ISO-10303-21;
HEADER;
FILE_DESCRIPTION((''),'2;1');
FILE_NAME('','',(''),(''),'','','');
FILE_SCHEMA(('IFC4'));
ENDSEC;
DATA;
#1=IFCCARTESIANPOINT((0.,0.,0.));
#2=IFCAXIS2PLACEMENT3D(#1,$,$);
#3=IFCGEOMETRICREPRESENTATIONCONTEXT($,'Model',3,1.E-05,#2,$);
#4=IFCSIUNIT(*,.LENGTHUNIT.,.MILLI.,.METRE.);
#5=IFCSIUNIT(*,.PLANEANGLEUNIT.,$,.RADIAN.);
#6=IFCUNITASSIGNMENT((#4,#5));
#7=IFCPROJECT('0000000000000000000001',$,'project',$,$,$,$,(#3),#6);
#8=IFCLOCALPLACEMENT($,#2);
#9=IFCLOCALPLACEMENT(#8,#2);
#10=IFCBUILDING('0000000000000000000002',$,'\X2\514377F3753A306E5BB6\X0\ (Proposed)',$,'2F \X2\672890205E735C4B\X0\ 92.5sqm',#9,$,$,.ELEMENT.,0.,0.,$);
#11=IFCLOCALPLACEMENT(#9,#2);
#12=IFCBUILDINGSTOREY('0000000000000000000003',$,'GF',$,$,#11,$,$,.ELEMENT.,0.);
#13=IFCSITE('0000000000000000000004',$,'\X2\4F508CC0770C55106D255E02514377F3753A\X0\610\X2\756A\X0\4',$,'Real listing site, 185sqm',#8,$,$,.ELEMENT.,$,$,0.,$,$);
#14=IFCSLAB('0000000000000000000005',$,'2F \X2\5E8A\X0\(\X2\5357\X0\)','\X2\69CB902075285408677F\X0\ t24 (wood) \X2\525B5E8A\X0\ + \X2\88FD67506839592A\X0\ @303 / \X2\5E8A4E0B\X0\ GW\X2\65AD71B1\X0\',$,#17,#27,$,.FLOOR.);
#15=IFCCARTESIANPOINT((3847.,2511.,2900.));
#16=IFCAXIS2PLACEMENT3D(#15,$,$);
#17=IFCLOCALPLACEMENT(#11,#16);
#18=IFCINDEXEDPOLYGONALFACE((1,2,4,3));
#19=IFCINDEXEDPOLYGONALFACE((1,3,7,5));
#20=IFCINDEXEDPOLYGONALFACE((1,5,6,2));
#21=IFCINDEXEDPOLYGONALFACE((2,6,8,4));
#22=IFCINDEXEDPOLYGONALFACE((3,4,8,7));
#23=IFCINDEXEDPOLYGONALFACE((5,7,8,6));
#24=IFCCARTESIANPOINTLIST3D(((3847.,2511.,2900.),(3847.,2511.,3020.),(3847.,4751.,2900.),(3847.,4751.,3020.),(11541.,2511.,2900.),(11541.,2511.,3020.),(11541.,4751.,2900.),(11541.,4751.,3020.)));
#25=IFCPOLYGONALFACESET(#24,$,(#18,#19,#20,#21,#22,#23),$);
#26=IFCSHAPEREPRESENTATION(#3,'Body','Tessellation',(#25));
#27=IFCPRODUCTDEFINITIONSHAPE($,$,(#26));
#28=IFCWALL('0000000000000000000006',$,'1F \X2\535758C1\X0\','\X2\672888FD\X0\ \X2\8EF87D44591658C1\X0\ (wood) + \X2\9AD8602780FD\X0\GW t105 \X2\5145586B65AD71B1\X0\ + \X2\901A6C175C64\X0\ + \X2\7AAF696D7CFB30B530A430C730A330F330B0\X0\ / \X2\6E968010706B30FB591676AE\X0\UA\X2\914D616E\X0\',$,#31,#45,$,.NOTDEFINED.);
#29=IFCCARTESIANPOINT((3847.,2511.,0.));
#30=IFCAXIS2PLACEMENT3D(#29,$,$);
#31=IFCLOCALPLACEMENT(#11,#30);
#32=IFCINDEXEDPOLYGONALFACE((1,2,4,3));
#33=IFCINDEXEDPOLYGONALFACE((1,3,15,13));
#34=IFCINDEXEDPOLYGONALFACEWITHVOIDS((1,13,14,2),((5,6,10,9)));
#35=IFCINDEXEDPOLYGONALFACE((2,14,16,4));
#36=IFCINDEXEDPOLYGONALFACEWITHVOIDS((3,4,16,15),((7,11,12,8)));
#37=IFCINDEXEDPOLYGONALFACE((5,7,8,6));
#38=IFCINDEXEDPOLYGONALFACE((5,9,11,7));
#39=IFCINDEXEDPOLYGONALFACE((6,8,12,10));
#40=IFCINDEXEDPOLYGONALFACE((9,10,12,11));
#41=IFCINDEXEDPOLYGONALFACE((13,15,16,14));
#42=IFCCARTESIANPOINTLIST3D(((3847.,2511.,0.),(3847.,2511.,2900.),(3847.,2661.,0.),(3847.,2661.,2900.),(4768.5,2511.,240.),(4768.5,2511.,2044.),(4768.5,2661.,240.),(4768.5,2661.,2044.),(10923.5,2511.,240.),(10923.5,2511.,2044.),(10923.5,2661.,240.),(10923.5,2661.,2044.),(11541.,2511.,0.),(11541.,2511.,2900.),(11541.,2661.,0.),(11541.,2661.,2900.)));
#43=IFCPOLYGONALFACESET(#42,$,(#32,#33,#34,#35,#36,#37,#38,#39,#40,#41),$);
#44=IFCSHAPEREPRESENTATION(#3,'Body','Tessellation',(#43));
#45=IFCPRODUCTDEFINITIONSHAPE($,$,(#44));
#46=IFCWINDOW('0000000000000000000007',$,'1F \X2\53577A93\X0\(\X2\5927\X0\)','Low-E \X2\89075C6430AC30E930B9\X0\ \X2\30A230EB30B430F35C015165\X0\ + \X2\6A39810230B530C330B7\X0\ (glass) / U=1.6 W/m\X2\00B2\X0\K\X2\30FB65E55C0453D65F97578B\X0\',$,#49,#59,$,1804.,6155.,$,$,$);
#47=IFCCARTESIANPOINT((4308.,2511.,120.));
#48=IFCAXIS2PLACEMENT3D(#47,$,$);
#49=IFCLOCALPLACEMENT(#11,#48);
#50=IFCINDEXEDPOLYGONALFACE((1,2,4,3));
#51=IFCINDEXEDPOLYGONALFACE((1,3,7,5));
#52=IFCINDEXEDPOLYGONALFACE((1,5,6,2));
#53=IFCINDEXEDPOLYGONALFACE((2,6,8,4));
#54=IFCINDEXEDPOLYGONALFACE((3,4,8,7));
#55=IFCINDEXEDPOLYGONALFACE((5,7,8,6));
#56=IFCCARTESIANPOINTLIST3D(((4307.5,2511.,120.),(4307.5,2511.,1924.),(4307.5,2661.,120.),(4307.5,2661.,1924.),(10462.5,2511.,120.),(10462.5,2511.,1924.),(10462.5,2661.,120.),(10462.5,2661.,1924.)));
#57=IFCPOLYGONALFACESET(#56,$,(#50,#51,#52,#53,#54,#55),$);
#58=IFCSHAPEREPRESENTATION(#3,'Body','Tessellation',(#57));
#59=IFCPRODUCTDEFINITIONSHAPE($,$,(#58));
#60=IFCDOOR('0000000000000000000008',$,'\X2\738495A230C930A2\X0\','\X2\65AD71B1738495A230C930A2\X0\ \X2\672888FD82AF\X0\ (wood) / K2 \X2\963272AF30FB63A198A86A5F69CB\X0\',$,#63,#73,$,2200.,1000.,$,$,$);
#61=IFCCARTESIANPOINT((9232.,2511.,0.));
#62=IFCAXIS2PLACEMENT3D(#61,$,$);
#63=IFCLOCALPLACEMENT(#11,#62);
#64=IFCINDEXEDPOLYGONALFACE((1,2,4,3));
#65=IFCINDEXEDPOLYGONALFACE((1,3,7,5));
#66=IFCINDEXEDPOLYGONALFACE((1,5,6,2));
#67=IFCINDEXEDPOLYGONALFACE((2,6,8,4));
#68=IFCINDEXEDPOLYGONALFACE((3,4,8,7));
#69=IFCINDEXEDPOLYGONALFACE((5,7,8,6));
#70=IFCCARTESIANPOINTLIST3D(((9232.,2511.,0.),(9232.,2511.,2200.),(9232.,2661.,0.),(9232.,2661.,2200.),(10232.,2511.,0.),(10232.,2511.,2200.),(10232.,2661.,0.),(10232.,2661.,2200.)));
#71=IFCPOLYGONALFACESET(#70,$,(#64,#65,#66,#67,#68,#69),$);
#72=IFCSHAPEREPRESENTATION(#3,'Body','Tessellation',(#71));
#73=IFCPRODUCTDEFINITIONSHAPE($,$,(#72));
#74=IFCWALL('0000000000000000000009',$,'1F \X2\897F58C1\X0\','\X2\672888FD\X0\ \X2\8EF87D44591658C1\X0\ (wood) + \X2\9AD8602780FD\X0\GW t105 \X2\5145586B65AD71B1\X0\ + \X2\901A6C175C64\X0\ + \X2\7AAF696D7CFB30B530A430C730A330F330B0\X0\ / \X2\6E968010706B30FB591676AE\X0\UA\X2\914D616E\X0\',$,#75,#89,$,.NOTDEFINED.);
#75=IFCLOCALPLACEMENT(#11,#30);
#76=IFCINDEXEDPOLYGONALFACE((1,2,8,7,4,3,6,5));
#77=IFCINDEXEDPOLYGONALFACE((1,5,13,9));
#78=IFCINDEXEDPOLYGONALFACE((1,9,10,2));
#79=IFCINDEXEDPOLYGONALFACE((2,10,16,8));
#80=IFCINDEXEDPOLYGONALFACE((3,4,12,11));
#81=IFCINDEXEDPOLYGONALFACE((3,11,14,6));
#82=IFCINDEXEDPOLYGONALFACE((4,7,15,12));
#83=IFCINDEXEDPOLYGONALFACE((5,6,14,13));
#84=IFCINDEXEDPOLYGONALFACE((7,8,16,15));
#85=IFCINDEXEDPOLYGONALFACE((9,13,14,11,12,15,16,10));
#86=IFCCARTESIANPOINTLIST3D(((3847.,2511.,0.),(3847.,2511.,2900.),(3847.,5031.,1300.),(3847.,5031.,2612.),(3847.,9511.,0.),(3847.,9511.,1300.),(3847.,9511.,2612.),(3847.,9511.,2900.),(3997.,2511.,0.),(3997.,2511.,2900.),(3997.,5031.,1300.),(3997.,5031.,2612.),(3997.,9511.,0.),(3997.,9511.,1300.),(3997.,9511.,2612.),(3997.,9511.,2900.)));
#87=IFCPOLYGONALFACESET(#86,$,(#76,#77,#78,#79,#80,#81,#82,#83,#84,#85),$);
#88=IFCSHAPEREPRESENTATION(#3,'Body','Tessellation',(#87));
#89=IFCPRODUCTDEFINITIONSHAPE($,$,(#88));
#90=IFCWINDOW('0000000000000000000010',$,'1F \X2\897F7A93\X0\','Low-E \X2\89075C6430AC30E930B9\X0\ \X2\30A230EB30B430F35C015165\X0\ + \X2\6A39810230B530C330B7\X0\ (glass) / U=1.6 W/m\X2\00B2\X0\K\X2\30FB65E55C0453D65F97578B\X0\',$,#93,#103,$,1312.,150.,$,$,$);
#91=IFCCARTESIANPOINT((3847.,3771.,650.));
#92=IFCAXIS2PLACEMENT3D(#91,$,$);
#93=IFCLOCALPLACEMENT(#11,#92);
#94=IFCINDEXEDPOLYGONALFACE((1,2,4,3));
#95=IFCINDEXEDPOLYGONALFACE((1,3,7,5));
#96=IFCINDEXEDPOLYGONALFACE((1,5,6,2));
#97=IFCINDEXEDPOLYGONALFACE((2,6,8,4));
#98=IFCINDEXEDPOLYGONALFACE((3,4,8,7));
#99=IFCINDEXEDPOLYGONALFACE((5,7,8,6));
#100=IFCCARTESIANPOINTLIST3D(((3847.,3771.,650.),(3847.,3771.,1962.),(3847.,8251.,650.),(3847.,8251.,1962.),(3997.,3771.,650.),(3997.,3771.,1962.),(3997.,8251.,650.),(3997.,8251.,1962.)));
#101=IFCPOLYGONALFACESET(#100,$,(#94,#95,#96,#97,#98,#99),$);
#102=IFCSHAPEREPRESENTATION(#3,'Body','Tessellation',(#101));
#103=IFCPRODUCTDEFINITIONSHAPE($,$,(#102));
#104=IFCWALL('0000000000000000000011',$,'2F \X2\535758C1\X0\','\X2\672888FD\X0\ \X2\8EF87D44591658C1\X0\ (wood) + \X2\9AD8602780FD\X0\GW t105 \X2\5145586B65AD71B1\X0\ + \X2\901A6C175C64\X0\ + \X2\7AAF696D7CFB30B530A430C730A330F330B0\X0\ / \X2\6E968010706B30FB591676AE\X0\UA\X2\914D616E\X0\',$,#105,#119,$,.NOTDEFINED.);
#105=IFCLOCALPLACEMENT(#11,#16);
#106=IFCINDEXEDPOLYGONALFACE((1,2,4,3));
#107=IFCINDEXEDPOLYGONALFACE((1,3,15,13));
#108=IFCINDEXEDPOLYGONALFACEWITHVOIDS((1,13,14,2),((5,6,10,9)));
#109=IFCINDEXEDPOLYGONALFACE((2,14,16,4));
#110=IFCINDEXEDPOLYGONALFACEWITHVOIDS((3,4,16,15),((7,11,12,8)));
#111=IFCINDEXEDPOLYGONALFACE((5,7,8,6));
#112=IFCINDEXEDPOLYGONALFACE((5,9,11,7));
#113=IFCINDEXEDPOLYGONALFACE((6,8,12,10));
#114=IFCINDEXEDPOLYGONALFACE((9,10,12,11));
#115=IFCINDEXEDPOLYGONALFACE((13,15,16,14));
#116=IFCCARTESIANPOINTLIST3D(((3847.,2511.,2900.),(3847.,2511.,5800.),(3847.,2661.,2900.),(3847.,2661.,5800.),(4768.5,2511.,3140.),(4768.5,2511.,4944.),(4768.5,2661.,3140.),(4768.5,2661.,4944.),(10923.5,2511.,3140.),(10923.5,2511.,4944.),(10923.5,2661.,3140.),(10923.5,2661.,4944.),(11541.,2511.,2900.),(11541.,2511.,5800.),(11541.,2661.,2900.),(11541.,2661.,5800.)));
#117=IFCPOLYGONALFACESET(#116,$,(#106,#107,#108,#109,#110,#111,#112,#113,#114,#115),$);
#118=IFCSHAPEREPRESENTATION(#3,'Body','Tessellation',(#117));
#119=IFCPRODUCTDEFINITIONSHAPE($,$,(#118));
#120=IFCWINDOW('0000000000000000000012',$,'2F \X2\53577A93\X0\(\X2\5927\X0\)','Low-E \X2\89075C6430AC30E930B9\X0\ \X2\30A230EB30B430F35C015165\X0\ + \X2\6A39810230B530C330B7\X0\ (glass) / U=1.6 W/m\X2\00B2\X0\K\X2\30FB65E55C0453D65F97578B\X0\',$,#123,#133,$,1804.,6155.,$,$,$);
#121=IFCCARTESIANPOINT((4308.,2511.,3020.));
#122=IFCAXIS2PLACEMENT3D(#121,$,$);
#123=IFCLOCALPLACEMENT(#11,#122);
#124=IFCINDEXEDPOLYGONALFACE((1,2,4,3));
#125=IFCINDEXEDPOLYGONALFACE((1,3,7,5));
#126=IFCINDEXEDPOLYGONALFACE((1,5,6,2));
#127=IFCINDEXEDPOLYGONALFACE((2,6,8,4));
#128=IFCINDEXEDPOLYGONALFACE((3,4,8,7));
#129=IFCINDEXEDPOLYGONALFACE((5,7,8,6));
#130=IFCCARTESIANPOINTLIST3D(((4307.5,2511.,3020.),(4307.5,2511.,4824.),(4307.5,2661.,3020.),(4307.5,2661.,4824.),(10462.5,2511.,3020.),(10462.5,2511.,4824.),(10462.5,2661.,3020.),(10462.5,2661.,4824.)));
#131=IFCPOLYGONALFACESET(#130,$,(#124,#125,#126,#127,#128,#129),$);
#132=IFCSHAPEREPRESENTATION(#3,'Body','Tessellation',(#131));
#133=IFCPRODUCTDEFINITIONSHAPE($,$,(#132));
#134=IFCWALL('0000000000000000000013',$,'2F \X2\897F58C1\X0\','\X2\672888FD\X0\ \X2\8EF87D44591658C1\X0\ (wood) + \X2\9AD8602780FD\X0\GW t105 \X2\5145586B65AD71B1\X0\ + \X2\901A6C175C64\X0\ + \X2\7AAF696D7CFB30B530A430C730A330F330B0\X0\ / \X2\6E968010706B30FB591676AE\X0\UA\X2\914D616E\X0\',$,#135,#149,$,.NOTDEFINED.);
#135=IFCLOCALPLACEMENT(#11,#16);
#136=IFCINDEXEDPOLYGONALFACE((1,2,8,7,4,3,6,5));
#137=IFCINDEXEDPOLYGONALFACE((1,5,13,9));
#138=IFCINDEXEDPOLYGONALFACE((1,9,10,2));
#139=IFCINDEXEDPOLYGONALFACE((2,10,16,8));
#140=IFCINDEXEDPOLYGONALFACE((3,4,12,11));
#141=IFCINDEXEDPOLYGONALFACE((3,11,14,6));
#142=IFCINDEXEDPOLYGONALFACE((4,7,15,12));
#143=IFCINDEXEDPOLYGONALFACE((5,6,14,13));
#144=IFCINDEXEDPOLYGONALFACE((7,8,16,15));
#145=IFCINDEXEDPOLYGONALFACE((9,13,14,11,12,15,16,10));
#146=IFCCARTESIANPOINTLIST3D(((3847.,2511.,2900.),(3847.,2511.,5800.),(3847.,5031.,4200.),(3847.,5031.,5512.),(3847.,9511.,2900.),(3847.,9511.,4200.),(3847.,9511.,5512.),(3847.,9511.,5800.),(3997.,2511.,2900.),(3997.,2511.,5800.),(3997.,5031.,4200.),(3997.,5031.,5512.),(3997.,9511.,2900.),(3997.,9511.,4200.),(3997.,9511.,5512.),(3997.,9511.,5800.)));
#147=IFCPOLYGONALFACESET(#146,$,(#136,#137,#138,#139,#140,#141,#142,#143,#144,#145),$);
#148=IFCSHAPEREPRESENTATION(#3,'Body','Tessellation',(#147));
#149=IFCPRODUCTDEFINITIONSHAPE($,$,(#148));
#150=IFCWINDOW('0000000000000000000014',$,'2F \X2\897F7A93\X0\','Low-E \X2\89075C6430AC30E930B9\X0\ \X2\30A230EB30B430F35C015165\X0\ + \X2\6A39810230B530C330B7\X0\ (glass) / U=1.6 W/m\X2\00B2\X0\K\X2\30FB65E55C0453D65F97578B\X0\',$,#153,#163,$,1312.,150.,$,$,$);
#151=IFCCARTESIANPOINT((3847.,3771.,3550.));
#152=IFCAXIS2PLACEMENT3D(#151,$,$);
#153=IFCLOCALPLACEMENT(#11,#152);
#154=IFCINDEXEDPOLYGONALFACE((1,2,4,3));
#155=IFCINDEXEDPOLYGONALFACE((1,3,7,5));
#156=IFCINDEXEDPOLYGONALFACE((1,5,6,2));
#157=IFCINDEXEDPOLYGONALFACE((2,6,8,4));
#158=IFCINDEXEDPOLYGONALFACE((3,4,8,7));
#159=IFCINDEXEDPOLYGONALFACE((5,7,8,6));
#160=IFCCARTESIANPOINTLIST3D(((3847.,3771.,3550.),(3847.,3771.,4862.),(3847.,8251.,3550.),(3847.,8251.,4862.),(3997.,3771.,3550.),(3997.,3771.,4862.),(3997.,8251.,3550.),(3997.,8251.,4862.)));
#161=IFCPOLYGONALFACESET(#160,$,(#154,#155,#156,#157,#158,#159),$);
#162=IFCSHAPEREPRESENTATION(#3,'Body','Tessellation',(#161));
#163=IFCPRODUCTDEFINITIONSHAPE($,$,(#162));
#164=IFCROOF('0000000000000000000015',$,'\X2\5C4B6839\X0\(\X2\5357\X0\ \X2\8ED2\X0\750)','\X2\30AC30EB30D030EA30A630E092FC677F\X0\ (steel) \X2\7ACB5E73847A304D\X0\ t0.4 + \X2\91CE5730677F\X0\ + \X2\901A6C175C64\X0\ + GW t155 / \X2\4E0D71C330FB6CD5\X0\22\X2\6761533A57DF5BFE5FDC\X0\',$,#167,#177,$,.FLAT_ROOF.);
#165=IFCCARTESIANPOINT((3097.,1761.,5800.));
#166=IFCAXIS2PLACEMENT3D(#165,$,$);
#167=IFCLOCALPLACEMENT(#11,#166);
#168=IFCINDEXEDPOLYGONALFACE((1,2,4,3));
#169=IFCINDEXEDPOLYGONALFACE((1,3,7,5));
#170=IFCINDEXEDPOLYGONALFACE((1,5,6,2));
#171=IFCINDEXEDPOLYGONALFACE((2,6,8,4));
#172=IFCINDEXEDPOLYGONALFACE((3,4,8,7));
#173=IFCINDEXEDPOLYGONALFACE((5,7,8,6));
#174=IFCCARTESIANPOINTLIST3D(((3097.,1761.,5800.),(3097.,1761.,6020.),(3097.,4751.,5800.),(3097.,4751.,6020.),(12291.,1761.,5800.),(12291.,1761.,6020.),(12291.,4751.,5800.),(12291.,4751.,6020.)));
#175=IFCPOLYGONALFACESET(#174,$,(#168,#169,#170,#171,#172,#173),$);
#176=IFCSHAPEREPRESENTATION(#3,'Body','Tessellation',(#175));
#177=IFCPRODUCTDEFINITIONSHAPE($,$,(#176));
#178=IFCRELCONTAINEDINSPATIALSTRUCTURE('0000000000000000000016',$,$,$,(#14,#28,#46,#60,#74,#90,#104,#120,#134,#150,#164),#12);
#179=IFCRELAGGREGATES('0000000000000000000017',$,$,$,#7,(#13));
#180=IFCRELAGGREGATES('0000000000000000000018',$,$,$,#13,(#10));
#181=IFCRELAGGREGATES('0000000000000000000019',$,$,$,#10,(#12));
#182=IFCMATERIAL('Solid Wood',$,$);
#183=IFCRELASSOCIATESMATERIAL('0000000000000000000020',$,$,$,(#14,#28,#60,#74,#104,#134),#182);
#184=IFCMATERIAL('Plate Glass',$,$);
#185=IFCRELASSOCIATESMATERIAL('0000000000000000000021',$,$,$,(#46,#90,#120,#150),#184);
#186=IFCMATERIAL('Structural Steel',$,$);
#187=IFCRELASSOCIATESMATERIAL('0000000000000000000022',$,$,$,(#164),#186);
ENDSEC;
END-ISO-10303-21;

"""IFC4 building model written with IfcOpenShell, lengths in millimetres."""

from ifc_helpers import new_model, si_unit, frame, frame_2d, origin, place, context, project, spatial, rectangle, extrude, material, element, fill, save


model = new_model("IFC4")

# Units and contexts
model_context = context("Model", 3, precision=1e-05, world=origin())
ifc_project = project(units=[si_unit("LENGTHUNIT", "METRE", prefix="MILLI"), si_unit("PLANEANGLEUNIT", "RADIAN")], contexts=[model_context])

# Site, building, storey
site_placement = place(None, origin())
site = spatial("IfcSite", under=ifc_project, at=site_placement, Name="佐賀県唐津市元石町610番4", ObjectType="Real listing site, 185sqm", CompositionType="ELEMENT", RefElevation=0.0)
building_placement = place(site_placement, origin())
building = spatial("IfcBuilding", under=site, at=building_placement, Name="元石町の家 (Proposed)", ObjectType="2F 木造平屋 92.5sqm", CompositionType="ELEMENT", ElevationOfRefHeight=0.0, ElevationOfTerrain=0.0)
storey_placement = place(building_placement, origin())
storey = spatial("IfcBuildingStorey", under=building, at=storey_placement, Name="GF", CompositionType="ELEMENT", Elevation=0.0)

# Slab
ifc_material_1 = material(Name="Solid Wood")
slab_1_placement = place(storey_placement, frame((3847.0, 2511.0, 2900.0)))
element("IfcSlab", 1, at=slab_1_placement, inside=storey, material=ifc_material_1, Name="2F 床(南)", Description="構造用合板 t24 (wood) 剛床 + 製材根太 @303 / 床下 GW断熱", PredefinedType="FLOOR", context=model_context, shape_type="SweptSolid", body=[
    extrude(rectangle(XDim=7694.0, YDim=2240.0, at=frame_2d((3847.0, 1120.0))), frame((3847.0, 2511.0, 2900.0)), (0.0, 0.0, 1.0), 120.0),
])

# Wall, openings, window, door
wall_1_placement = place(storey_placement, frame((3847.0, 2511.0, 0.0)))
wall_1 = element("IfcWall", 2, at=wall_1_placement, inside=storey, material=ifc_material_1, Name="1F 南壁", Description="木製 軸組外壁 (wood) + 高性能GW t105 充填断熱 + 通気層 + 窯業系サイディング / 準耐火・外皮UA配慮", PredefinedType="NOTDEFINED", context=model_context, shape_type="SweptSolid", body=[
    extrude(rectangle(XDim=7694.0, YDim=150.0, at=frame_2d((3847.0, 75.0))), frame((3847.0, 2511.0, 0.0)), (0.0, 0.0, 1.0), 2900.0),
])
opening_1_placement = place(storey_placement, frame((4308.0, 2511.0, 120.0)))
opening_1 = element("IfcOpeningElement", 3, at=opening_1_placement, cuts=wall_1, PredefinedType="NOTDEFINED", context=model_context, shape_type="SweptSolid", body=[
    extrude(rectangle(XDim=6155.0, YDim=150.0, at=frame_2d((3077.0, 75.0))), frame((4308.0, 2511.0, 120.0)), (0.0, 0.0, 1.0), 1804.0),
])
opening_2_placement = place(storey_placement, frame((9232.0, 2511.0, 0.0)))
opening_2 = element("IfcOpeningElement", 4, at=opening_2_placement, cuts=wall_1, PredefinedType="NOTDEFINED", context=model_context, shape_type="SweptSolid", body=[
    extrude(rectangle(XDim=1000.0, YDim=150.0, at=frame_2d((500.0, 75.0))), frame((9232.0, 2511.0, 0.0)), (0.0, 0.0, 1.0), 2200.0),
])
ifc_material_2 = material(Name="Plate Glass")
window_1_placement = place(storey_placement, frame((4308.0, 2511.0, 120.0)))
window_1 = element("IfcWindow", 5, at=window_1_placement, inside=storey, material=ifc_material_2, Name="1F 南窓(大)", Description="Low-E 複層ガラス アルゴン封入 + 樹脂サッシ (glass) / U=1.6 W/m²K・日射取得型", OverallHeight=1804.0, OverallWidth=6155.0, context=model_context, shape_type="SweptSolid", body=[
    extrude(rectangle(XDim=6155.0, YDim=150.0, at=frame_2d((3077.0, 75.0))), frame((4308.0, 2511.0, 120.0)), (0.0, 0.0, 1.0), 1804.0),
])
fill(opening_1, window_1)
door_placement = place(storey_placement, frame((9232.0, 2511.0, 0.0)))
door = element("IfcDoor", 6, at=door_placement, inside=storey, material=ifc_material_1, Name="玄関ドア", Description="断熱玄関ドア 木製芯 (wood) / K2 防犯・採風機構", OverallHeight=2200.0, OverallWidth=1000.0, context=model_context, shape_type="SweptSolid", body=[
    extrude(rectangle(XDim=1000.0, YDim=150.0, at=frame_2d((500.0, 75.0))), frame((9232.0, 2511.0, 0.0)), (0.0, 0.0, 1.0), 2200.0),
])
fill(opening_2, door)

# Walls, openings, windows
wall_2_placement = place(storey_placement, frame((3847.0, 2511.0, 0.0)))
wall_2 = element("IfcWall", 7, at=wall_2_placement, inside=storey, material=ifc_material_1, Name="1F 西壁", Description="木製 軸組外壁 (wood) + 高性能GW t105 充填断熱 + 通気層 + 窯業系サイディング / 準耐火・外皮UA配慮", PredefinedType="NOTDEFINED", context=model_context, shape_type="SweptSolid", body=[
    extrude(rectangle(XDim=150.0, YDim=7000.0, at=frame_2d((75.0, 3500.0))), frame((3847.0, 2511.0, 0.0)), (0.0, 0.0, 1.0), 2900.0),
])
opening_3_placement = place(storey_placement, frame((3847.0, 3771.0, 650.0)))
opening_3 = element("IfcOpeningElement", 8, at=opening_3_placement, cuts=wall_2, PredefinedType="NOTDEFINED", context=model_context, shape_type="SweptSolid", body=[
    extrude(rectangle(XDim=150.0, YDim=4480.0, at=frame_2d((75.0, 2240.0))), frame((3847.0, 3771.0, 650.0)), (0.0, 0.0, 1.0), 1312.0),
])
window_2_placement = place(storey_placement, frame((3847.0, 3771.0, 650.0)))
window_2 = element("IfcWindow", 9, at=window_2_placement, inside=storey, material=ifc_material_2, Name="1F 西窓", Description="Low-E 複層ガラス アルゴン封入 + 樹脂サッシ (glass) / U=1.6 W/m²K・日射取得型", OverallHeight=1312.0, OverallWidth=150.0, context=model_context, shape_type="SweptSolid", body=[
    extrude(rectangle(XDim=150.0, YDim=4480.0, at=frame_2d((75.0, 2240.0))), frame((3847.0, 3771.0, 650.0)), (0.0, 0.0, 1.0), 1312.0),
])
fill(opening_3, window_2)
wall_3_placement = place(storey_placement, frame((3847.0, 2511.0, 2900.0)))
wall_3 = element("IfcWall", 10, at=wall_3_placement, inside=storey, material=ifc_material_1, Name="2F 南壁", Description="木製 軸組外壁 (wood) + 高性能GW t105 充填断熱 + 通気層 + 窯業系サイディング / 準耐火・外皮UA配慮", PredefinedType="NOTDEFINED", context=model_context, shape_type="SweptSolid", body=[
    extrude(rectangle(XDim=7694.0, YDim=150.0, at=frame_2d((3847.0, 75.0))), frame((3847.0, 2511.0, 2900.0)), (0.0, 0.0, 1.0), 2900.0),
])
opening_4_placement = place(storey_placement, frame((4308.0, 2511.0, 3020.0)))
opening_4 = element("IfcOpeningElement", 11, at=opening_4_placement, cuts=wall_3, PredefinedType="NOTDEFINED", context=model_context, shape_type="SweptSolid", body=[
    extrude(rectangle(XDim=6155.0, YDim=150.0, at=frame_2d((3077.0, 75.0))), frame((4308.0, 2511.0, 3020.0)), (0.0, 0.0, 1.0), 1804.0),
])
window_3_placement = place(storey_placement, frame((4308.0, 2511.0, 3020.0)))
window_3 = element("IfcWindow", 12, at=window_3_placement, inside=storey, material=ifc_material_2, Name="2F 南窓(大)", Description="Low-E 複層ガラス アルゴン封入 + 樹脂サッシ (glass) / U=1.6 W/m²K・日射取得型", OverallHeight=1804.0, OverallWidth=6155.0, context=model_context, shape_type="SweptSolid", body=[
    extrude(rectangle(XDim=6155.0, YDim=150.0, at=frame_2d((3077.0, 75.0))), frame((4308.0, 2511.0, 3020.0)), (0.0, 0.0, 1.0), 1804.0),
])
fill(opening_4, window_3)
wall_4_placement = place(storey_placement, frame((3847.0, 2511.0, 2900.0)))
wall_4 = element("IfcWall", 13, at=wall_4_placement, inside=storey, material=ifc_material_1, Name="2F 西壁", Description="木製 軸組外壁 (wood) + 高性能GW t105 充填断熱 + 通気層 + 窯業系サイディング / 準耐火・外皮UA配慮", PredefinedType="NOTDEFINED", context=model_context, shape_type="SweptSolid", body=[
    extrude(rectangle(XDim=150.0, YDim=7000.0, at=frame_2d((75.0, 3500.0))), frame((3847.0, 2511.0, 2900.0)), (0.0, 0.0, 1.0), 2900.0),
])
opening_5_placement = place(storey_placement, frame((3847.0, 3771.0, 3550.0)))
opening_5 = element("IfcOpeningElement", 14, at=opening_5_placement, cuts=wall_4, PredefinedType="NOTDEFINED", context=model_context, shape_type="SweptSolid", body=[
    extrude(rectangle(XDim=150.0, YDim=4480.0, at=frame_2d((75.0, 2240.0))), frame((3847.0, 3771.0, 3550.0)), (0.0, 0.0, 1.0), 1312.0),
])
window_4_placement = place(storey_placement, frame((3847.0, 3771.0, 3550.0)))
window_4 = element("IfcWindow", 15, at=window_4_placement, inside=storey, material=ifc_material_2, Name="2F 西窓", Description="Low-E 複層ガラス アルゴン封入 + 樹脂サッシ (glass) / U=1.6 W/m²K・日射取得型", OverallHeight=1312.0, OverallWidth=150.0, context=model_context, shape_type="SweptSolid", body=[
    extrude(rectangle(XDim=150.0, YDim=4480.0, at=frame_2d((75.0, 2240.0))), frame((3847.0, 3771.0, 3550.0)), (0.0, 0.0, 1.0), 1312.0),
])
fill(opening_5, window_4)

# Roof
ifc_material_3 = material(Name="Structural Steel")
roof_1_placement = place(storey_placement, frame((3097.0, 1761.0, 5800.0)))
element("IfcRoof", 16, at=roof_1_placement, inside=storey, material=ifc_material_3, Name="屋根(南 軒750)", Description="ガルバリウム鋼板 (steel) 立平葺き t0.4 + 野地板 + 通気層 + GW t155 / 不燃・法22条区域対応", PredefinedType="FLAT_ROOF", context=model_context, shape_type="SweptSolid", body=[
    extrude(rectangle(XDim=9194.0, YDim=2990.0, at=frame_2d((4597.0, 1495.0))), frame((3097.0, 1761.0, 5800.0)), (0.0, 0.0, 1.0), 220.0),
])

save(model, "model.ifc")
